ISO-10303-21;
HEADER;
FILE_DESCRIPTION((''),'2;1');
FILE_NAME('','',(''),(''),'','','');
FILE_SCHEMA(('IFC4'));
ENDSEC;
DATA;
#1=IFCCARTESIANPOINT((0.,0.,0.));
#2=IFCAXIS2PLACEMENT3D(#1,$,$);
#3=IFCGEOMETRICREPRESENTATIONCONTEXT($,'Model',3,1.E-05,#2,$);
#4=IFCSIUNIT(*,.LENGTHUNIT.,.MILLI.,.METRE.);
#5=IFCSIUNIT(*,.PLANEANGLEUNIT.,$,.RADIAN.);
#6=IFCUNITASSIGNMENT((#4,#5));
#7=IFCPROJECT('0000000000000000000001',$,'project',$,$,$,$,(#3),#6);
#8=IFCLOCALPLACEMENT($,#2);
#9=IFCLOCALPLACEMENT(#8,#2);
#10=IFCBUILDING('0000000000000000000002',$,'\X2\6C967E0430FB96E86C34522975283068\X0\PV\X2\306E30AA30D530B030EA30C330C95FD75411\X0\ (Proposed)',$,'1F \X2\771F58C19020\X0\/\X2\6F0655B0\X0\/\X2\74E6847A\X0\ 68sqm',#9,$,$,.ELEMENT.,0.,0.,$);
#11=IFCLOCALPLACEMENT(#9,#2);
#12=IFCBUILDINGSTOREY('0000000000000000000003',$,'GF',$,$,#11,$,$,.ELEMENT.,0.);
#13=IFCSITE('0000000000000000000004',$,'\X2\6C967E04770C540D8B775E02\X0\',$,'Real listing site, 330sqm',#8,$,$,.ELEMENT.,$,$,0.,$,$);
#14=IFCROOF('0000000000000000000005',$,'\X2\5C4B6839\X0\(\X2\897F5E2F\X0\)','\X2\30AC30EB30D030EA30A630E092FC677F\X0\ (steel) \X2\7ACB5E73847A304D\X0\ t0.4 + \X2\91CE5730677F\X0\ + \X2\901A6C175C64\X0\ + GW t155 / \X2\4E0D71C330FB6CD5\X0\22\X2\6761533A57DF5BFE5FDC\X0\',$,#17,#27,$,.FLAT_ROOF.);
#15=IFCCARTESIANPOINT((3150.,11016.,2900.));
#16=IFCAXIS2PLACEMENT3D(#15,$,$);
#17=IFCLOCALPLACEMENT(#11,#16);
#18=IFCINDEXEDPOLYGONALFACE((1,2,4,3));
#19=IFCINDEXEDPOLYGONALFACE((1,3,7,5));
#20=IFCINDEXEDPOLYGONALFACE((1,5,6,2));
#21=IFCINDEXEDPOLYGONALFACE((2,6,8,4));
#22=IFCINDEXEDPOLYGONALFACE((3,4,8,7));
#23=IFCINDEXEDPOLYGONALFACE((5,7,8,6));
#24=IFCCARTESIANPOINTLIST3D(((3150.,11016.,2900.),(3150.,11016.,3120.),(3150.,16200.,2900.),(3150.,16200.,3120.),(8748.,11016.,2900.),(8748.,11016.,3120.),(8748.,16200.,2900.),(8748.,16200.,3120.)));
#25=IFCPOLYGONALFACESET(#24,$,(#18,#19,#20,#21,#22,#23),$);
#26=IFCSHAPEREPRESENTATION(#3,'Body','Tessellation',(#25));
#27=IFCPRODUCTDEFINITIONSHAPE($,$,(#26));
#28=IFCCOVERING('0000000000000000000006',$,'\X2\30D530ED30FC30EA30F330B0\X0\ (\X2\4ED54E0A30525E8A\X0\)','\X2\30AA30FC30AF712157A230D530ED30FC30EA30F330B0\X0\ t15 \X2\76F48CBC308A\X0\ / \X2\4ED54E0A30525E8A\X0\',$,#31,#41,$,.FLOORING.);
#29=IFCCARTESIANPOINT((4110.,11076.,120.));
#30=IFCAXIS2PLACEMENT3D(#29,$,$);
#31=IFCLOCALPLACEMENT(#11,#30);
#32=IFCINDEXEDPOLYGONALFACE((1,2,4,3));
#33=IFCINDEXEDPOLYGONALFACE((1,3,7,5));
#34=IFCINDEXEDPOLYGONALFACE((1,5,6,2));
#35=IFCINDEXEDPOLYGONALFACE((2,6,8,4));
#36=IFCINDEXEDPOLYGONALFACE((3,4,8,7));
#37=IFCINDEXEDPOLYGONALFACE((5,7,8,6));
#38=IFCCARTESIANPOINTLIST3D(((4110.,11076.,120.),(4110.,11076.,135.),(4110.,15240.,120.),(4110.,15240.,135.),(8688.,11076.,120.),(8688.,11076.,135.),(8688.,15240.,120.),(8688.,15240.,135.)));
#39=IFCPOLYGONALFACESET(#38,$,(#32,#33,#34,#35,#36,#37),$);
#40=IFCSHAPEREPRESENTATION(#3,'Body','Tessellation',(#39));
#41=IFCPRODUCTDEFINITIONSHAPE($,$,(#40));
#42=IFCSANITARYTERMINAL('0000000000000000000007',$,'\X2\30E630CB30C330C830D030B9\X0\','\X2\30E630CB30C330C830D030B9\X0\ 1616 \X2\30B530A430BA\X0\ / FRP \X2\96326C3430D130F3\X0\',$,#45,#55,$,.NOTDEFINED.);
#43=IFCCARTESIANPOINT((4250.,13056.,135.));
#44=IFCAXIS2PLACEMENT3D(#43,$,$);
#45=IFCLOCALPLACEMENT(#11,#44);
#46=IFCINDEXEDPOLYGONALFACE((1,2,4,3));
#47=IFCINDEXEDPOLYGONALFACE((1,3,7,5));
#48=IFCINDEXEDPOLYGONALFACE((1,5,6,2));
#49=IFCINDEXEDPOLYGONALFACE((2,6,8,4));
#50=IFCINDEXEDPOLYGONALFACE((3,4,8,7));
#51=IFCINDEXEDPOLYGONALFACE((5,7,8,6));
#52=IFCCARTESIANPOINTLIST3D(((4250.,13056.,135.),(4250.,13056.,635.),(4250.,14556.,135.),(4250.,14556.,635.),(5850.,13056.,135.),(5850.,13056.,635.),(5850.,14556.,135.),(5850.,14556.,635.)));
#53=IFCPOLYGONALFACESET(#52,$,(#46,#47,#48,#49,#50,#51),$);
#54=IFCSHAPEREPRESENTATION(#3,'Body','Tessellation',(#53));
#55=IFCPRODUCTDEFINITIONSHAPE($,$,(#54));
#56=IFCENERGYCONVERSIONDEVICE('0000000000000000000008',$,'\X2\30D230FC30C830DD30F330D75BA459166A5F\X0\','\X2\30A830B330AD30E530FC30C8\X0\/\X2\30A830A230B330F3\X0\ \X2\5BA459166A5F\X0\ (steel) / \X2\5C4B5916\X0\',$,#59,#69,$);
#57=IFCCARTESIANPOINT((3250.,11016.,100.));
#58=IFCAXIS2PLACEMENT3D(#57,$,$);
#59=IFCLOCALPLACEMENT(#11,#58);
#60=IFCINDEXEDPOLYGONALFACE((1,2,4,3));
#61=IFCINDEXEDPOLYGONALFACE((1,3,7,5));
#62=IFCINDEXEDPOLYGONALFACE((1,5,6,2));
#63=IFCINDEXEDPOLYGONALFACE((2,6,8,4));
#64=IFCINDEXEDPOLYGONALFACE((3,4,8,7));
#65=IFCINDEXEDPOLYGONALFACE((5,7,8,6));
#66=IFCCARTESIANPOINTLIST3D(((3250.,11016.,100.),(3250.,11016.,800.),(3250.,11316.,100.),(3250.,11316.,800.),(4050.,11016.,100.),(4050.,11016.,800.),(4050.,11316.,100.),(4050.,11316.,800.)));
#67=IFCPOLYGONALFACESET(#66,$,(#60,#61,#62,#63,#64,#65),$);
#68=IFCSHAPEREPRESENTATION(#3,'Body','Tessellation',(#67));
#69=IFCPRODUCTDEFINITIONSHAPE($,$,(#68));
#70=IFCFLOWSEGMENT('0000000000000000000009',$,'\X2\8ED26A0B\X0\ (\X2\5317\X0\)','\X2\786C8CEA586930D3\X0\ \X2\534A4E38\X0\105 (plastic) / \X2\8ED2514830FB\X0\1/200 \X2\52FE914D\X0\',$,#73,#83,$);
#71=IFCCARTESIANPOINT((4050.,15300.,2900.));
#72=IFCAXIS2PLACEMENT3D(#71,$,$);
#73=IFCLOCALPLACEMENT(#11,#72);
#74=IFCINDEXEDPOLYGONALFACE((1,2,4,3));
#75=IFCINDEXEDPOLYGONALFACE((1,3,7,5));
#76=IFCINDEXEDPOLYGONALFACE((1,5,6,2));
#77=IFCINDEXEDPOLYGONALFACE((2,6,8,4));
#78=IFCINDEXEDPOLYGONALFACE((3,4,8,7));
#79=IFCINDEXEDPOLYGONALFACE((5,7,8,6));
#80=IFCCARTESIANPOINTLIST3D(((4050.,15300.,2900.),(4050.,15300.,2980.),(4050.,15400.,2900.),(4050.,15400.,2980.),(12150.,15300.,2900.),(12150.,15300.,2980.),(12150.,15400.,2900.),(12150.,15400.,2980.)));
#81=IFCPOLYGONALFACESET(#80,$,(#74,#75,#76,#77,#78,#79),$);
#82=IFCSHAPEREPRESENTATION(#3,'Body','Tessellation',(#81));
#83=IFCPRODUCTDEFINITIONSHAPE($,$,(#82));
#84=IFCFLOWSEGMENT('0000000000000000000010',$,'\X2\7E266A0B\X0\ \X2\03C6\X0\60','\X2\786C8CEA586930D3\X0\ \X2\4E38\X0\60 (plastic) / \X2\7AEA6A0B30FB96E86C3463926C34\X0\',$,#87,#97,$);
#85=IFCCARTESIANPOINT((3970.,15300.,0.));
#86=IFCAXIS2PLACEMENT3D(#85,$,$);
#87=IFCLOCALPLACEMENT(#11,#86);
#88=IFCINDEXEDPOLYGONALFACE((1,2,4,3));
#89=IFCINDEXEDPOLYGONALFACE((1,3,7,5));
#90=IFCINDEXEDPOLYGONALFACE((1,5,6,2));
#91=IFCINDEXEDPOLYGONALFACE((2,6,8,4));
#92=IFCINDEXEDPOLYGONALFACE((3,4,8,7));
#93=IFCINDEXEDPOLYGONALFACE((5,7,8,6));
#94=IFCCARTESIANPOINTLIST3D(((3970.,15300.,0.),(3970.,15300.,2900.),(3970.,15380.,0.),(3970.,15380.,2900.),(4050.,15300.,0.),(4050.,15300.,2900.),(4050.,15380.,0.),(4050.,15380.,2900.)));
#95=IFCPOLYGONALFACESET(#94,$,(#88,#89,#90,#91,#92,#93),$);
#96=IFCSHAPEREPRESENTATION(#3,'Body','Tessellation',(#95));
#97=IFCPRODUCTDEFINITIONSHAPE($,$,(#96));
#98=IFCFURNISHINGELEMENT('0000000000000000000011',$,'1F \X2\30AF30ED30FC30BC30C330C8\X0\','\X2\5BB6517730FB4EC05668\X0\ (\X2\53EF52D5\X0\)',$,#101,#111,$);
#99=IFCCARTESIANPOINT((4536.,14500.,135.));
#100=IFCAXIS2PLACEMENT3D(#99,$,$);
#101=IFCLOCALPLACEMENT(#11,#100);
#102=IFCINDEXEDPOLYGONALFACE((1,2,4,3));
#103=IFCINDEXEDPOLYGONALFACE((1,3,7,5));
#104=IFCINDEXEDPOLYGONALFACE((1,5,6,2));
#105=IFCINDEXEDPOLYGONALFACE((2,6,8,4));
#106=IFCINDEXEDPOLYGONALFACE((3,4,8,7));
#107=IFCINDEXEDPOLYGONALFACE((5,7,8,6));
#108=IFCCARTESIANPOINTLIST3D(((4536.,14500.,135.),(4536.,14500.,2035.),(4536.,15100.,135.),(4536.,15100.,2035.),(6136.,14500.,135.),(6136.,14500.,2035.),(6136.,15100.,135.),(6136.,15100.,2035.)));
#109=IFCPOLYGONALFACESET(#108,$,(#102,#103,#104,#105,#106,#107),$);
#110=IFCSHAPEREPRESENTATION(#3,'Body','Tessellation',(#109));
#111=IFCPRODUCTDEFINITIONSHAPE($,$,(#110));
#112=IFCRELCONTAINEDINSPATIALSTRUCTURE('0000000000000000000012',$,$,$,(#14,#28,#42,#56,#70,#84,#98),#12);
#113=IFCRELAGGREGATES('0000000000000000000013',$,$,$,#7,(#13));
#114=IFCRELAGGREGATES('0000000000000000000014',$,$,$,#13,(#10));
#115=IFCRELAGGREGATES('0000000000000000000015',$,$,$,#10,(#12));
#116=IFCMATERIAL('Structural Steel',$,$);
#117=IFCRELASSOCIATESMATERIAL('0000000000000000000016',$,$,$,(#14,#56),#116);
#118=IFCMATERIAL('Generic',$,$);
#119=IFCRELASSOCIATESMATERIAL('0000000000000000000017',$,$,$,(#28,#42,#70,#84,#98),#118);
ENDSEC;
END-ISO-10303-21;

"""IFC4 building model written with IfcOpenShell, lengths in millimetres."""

from ifc_helpers import new_model, si_unit, frame, frame_2d, origin, place, context, project, spatial, rectangle, extrude, material, element, save


model = new_model("IFC4")

# Units and contexts
model_context = context("Model", 3, precision=1e-05, world=origin())
ifc_project = project(units=[si_unit("LENGTHUNIT", "METRE", prefix="MILLI"), si_unit("PLANEANGLEUNIT", "RADIAN")], contexts=[model_context])

# Site, building, storey
site_placement = place(None, origin())
site = spatial("IfcSite", under=ifc_project, at=site_placement, Name="沖縄県名護市", ObjectType="Real listing site, 330sqm", CompositionType="ELEMENT", RefElevation=0.0)
building_placement = place(site_placement, origin())
building = spatial("IfcBuilding", under=site, at=building_placement, Name="沖縄・雨水利用とPVのオフグリッド志向 (Proposed)", ObjectType="1F 真壁造/漆喰/瓦葺 68sqm", CompositionType="ELEMENT", ElevationOfRefHeight=0.0, ElevationOfTerrain=0.0)
storey_placement = place(building_placement, origin())
storey = spatial("IfcBuildingStorey", under=building, at=storey_placement, Name="GF", CompositionType="ELEMENT", Elevation=0.0)

# Roof
ifc_material_1 = material(Name="Structural Steel")
roof_placement = place(storey_placement, frame((3150.0, 11016.0, 2900.0)))
element("IfcRoof", 1, at=roof_placement, inside=storey, material=ifc_material_1, Name="屋根(西帯)", Description="ガルバリウム鋼板 (steel) 立平葺き t0.4 + 野地板 + 通気層 + GW t155 / 不燃・法22条区域対応", PredefinedType="FLAT_ROOF", context=model_context, shape_type="SweptSolid", body=[
    extrude(rectangle(XDim=5598.0, YDim=5184.0, at=frame_2d((2799.0, 2592.0))), frame((3150.0, 11016.0, 2900.0)), (0.0, 0.0, 1.0), 220.0),
])

# Covering
ifc_material_2 = material(Name="Generic")
covering_placement = place(storey_placement, frame((4110.0, 11076.0, 120.0)))
element("IfcCovering", 2, at=covering_placement, inside=storey, material=ifc_material_2, Name="フローリング (仕上げ床)", Description="オーク無垢フローリング t15 直貼り / 仕上げ床", PredefinedType="FLOORING", context=model_context, shape_type="SweptSolid", body=[
    extrude(rectangle(XDim=4578.0, YDim=4164.0, at=frame_2d((2289.0, 2082.0))), frame((4110.0, 11076.0, 120.0)), (0.0, 0.0, 1.0), 15.0),
])

# Sanitary terminal
sanitary_terminal_placement = place(storey_placement, frame((4250.0, 13056.0, 135.0)))
element("IfcSanitaryTerminal", 3, at=sanitary_terminal_placement, inside=storey, material=ifc_material_2, Name="ユニットバス", Description="ユニットバス 1616 サイズ / FRP 防水パン", PredefinedType="NOTDEFINED", context=model_context, shape_type="SweptSolid", body=[
    extrude(rectangle(XDim=1600.0, YDim=1500.0, at=frame_2d((800.0, 750.0))), frame((4250.0, 13056.0, 135.0)), (0.0, 0.0, 1.0), 500.0),
])

# Energy conversion device
energy_conversion_device_placement = place(storey_placement, frame((3250.0, 11016.0, 100.0)))
element("IfcEnergyConversionDevice", 4, at=energy_conversion_device_placement, inside=storey, material=ifc_material_1, Name="ヒートポンプ室外機", Description="エコキュート/エアコン 室外機 (steel) / 屋外", context=model_context, shape_type="SweptSolid", body=[
    extrude(rectangle(XDim=800.0, YDim=300.0, at=frame_2d((400.0, 150.0))), frame((3250.0, 11016.0, 100.0)), (0.0, 0.0, 1.0), 700.0),
])

# Flow segments
flow_segment_1_placement = place(storey_placement, frame((4050.0, 15300.0, 2900.0)))
element("IfcFlowSegment", 5, at=flow_segment_1_placement, inside=storey, material=ifc_material_2, Name="軒樋 (北)", Description="硬質塩ビ 半丸105 (plastic) / 軒先・1/200 勾配", context=model_context, shape_type="SweptSolid", body=[
    extrude(rectangle(XDim=8100.0, YDim=100.0, at=frame_2d((4050.0, 50.0))), frame((4050.0, 15300.0, 2900.0)), (0.0, 0.0, 1.0), 80.0),
])
flow_segment_2_placement = place(storey_placement, frame((3970.0, 15300.0, 0.0)))
element("IfcFlowSegment", 6, at=flow_segment_2_placement, inside=storey, material=ifc_material_2, Name="縦樋 φ60", Description="硬質塩ビ 丸60 (plastic) / 竪樋・雨水排水", context=model_context, shape_type="SweptSolid", body=[
    extrude(rectangle(XDim=80.0, YDim=80.0, at=frame_2d((40.0, 40.0))), frame((3970.0, 15300.0, 0.0)), (0.0, 0.0, 1.0), 2900.0),
])

# Furnishing element
furnishing_placement = place(storey_placement, frame((4536.0, 14500.0, 135.0)))
element("IfcFurnishingElement", 7, at=furnishing_placement, inside=storey, material=ifc_material_2, Name="1F クローゼット", Description="家具・什器 (可動)", context=model_context, shape_type="SweptSolid", body=[
    extrude(rectangle(XDim=1600.0, YDim=600.0, at=frame_2d((800.0, 300.0))), frame((4536.0, 14500.0, 135.0)), (0.0, 0.0, 1.0), 1900.0),
])

save(model, "model.ifc")
